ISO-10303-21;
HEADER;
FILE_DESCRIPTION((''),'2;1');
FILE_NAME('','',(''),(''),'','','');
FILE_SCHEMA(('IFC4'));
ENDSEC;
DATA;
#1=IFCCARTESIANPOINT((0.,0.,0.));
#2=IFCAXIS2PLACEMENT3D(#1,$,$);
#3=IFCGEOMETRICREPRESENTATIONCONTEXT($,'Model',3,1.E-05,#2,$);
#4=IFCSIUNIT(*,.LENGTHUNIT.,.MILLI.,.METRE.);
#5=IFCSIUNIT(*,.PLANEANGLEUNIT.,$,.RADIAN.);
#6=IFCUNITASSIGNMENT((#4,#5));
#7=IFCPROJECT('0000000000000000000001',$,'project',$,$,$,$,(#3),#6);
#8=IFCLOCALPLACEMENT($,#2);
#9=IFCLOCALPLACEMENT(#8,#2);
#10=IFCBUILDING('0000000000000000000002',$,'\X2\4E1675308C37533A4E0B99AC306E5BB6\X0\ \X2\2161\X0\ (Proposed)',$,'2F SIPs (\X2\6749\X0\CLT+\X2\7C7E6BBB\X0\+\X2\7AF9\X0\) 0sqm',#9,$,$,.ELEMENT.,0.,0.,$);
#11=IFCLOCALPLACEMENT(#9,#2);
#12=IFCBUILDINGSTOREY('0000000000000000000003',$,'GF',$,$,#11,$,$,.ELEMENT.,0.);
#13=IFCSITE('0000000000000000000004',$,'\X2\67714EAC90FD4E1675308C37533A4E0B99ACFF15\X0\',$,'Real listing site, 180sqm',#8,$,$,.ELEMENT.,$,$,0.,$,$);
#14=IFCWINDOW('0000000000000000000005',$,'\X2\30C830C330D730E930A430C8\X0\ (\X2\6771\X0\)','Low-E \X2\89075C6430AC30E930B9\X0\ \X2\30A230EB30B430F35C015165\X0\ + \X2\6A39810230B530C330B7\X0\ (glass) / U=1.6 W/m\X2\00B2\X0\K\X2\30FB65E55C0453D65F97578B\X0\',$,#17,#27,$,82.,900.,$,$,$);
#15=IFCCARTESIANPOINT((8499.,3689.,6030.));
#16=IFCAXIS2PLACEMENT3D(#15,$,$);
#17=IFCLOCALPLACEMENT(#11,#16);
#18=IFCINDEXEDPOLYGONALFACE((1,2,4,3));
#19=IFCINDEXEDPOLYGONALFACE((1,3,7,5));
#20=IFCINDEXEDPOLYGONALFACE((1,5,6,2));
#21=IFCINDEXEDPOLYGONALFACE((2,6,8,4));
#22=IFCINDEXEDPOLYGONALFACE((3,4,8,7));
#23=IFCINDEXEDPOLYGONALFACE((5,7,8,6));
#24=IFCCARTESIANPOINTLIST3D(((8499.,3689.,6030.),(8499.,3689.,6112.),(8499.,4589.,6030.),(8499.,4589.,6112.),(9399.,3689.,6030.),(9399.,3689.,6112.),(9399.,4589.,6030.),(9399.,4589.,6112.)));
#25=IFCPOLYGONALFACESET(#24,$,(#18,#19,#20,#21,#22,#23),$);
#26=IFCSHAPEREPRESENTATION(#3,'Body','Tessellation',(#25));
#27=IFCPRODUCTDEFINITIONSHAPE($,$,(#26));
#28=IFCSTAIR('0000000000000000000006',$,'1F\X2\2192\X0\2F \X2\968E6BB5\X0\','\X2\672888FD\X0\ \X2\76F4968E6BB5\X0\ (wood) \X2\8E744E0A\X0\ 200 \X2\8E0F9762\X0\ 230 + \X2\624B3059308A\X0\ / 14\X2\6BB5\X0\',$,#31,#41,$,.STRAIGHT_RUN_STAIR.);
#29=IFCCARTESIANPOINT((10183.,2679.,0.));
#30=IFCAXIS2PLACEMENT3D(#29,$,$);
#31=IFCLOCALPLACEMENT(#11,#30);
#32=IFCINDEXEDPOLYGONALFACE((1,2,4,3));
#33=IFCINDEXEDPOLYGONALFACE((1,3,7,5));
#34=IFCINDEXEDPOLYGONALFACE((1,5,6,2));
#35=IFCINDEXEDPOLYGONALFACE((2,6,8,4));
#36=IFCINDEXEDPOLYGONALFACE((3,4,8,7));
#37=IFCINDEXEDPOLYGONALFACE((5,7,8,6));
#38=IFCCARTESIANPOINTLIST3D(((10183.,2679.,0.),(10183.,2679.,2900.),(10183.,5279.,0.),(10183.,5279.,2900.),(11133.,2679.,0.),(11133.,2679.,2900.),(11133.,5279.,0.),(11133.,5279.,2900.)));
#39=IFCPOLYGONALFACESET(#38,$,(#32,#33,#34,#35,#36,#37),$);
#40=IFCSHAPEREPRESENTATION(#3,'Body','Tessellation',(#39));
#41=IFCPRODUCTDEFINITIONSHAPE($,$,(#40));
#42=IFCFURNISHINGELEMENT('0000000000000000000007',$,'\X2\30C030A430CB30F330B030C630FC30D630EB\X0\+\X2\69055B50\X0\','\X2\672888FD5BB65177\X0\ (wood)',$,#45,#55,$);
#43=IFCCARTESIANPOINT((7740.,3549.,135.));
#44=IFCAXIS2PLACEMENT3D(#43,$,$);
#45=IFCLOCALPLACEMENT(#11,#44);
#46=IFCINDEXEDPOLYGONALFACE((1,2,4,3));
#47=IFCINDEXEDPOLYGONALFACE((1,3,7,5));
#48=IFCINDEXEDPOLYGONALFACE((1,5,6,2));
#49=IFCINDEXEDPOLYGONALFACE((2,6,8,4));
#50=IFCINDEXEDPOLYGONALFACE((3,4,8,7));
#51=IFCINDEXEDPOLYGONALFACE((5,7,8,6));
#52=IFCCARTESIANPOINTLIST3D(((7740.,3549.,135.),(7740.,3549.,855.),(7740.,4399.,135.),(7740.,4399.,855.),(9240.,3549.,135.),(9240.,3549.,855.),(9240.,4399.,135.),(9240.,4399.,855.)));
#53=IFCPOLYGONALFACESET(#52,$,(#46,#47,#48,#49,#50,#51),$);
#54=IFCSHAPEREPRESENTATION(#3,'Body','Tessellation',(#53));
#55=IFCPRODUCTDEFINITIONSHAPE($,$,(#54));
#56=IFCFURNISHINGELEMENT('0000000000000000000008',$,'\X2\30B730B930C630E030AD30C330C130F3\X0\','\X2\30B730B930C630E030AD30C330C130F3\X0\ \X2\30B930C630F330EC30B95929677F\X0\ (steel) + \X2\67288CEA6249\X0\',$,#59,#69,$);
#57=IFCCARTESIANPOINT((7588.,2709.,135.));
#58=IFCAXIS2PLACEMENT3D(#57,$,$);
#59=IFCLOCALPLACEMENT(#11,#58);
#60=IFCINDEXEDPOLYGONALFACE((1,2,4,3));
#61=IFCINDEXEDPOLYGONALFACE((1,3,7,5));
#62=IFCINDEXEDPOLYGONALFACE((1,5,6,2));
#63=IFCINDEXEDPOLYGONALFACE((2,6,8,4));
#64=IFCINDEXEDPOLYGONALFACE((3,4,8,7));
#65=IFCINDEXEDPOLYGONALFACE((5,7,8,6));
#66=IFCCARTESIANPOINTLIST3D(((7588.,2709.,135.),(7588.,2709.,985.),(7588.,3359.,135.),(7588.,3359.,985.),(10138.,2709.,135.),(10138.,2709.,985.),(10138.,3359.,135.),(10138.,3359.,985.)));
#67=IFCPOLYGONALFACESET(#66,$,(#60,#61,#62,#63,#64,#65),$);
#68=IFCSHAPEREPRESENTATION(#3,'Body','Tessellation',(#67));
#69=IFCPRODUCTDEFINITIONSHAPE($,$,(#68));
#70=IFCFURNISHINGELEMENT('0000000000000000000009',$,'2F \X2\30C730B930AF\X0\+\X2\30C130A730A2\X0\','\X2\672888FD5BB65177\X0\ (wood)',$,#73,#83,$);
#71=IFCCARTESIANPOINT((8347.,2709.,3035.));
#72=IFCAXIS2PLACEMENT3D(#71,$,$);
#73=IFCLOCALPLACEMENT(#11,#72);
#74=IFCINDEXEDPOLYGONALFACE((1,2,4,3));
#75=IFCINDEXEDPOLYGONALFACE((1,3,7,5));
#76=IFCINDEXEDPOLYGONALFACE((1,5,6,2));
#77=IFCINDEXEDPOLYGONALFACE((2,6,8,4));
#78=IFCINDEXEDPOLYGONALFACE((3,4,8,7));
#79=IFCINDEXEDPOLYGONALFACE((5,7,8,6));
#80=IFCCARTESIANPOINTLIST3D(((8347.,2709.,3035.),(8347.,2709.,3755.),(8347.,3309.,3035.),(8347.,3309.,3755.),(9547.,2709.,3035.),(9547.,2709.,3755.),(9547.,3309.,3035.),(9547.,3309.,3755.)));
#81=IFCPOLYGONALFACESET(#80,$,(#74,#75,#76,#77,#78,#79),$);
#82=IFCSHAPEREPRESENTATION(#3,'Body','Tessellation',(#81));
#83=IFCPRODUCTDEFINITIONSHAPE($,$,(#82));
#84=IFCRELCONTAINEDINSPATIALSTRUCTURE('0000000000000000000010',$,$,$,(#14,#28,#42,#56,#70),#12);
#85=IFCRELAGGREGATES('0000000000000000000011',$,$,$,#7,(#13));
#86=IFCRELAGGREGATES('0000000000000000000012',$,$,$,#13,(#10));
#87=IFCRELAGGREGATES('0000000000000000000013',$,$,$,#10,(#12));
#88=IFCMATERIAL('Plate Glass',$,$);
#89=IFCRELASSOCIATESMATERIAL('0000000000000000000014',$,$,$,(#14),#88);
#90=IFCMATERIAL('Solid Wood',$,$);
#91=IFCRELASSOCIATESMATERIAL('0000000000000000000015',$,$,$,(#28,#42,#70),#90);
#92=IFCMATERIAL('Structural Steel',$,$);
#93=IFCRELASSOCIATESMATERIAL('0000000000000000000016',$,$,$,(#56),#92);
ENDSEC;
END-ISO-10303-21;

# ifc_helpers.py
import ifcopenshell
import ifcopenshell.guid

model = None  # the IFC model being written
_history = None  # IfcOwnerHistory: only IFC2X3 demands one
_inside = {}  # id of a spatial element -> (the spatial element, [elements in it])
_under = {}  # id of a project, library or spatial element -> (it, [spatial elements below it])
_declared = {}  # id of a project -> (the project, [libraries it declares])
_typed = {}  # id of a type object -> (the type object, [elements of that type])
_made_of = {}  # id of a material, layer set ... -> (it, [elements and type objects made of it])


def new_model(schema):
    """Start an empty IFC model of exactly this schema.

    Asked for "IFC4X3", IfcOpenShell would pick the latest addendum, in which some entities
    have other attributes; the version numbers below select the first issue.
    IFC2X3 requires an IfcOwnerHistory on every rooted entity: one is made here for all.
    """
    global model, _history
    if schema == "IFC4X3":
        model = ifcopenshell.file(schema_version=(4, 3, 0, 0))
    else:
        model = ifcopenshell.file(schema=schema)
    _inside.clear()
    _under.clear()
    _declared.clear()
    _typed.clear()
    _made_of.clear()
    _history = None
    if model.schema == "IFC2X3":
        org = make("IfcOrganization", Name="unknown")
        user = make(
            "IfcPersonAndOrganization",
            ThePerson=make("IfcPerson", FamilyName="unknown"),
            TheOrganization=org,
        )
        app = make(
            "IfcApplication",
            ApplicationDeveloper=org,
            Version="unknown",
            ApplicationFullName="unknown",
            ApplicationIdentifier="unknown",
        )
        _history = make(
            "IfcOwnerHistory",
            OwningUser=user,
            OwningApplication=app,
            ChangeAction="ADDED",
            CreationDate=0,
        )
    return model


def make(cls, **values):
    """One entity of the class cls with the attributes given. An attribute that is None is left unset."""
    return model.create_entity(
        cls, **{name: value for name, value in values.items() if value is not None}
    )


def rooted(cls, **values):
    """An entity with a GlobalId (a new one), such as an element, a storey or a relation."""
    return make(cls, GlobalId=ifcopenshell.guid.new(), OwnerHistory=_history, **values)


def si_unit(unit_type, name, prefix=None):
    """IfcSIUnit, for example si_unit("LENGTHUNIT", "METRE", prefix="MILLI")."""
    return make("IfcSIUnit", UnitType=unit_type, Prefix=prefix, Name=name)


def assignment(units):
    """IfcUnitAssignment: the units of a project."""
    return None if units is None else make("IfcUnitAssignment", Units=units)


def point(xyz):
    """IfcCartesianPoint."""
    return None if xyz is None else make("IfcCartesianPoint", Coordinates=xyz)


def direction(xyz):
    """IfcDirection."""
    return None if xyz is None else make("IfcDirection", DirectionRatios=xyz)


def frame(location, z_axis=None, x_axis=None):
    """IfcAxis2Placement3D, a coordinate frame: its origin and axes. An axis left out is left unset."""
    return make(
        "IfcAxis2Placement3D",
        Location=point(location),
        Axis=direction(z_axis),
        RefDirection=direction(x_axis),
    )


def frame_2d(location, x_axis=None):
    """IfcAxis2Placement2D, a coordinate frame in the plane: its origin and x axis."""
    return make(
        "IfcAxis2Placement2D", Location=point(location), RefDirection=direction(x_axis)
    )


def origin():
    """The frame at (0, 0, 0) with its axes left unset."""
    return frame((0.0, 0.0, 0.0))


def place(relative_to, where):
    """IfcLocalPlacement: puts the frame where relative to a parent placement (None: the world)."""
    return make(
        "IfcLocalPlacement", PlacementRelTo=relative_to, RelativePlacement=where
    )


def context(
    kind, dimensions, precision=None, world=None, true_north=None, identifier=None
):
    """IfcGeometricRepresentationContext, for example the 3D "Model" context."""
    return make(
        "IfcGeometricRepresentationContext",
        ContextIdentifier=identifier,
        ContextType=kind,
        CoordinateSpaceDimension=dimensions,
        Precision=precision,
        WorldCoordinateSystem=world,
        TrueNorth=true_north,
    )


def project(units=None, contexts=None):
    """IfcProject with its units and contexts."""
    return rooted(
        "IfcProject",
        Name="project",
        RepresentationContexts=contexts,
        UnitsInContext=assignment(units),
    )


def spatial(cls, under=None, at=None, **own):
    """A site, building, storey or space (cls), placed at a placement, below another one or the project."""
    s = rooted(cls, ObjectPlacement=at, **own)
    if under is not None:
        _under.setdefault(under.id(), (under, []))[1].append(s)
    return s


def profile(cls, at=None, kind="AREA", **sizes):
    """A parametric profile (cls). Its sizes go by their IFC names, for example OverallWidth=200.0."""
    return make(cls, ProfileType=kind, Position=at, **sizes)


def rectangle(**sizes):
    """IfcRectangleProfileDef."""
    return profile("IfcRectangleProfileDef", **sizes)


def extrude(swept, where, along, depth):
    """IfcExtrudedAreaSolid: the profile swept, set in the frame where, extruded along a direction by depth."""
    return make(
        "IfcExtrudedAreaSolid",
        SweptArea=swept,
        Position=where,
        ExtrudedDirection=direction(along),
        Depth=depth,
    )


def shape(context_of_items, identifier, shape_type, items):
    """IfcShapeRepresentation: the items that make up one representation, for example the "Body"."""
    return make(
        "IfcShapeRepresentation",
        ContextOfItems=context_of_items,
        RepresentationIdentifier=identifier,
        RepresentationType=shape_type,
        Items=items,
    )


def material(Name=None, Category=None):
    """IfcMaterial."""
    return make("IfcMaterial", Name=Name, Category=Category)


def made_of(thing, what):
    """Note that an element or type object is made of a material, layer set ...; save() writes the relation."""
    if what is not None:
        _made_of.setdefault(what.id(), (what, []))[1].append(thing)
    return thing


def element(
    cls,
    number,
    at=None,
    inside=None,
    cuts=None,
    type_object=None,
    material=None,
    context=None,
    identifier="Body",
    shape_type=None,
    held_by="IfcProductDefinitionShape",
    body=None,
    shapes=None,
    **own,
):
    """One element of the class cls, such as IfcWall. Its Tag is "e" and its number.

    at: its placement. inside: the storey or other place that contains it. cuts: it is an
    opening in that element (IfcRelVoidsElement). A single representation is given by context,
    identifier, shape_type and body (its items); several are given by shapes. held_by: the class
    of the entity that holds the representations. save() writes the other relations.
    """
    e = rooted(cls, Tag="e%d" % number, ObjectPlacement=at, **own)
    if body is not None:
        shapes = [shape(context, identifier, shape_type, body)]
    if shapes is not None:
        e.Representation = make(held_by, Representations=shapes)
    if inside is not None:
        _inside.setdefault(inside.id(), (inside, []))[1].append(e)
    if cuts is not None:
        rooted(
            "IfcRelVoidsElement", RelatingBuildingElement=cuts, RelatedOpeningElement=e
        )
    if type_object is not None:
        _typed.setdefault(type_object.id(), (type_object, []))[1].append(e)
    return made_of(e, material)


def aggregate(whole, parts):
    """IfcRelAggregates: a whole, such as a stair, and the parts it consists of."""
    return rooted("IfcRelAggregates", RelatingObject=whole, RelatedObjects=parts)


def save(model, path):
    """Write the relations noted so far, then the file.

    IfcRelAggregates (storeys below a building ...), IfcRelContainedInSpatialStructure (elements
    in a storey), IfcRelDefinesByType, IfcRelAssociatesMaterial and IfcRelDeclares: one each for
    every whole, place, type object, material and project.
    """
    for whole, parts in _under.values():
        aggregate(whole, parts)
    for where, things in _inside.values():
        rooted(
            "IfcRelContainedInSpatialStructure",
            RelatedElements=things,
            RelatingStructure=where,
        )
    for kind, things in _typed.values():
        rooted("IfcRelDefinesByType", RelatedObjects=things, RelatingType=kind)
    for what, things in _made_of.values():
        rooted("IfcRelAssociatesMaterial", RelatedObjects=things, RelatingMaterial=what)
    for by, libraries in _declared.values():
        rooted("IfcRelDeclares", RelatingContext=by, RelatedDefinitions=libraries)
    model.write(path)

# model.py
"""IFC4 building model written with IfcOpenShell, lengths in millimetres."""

from ifc_helpers import new_model, si_unit, frame, frame_2d, origin, place, context, project, spatial, rectangle, extrude, material, element, save


model = new_model("IFC4")

# Units and contexts
model_context = context("Model", 3, precision=1e-05, world=origin())
ifc_project = project(units=[si_unit("LENGTHUNIT", "METRE", prefix="MILLI"), si_unit("PLANEANGLEUNIT", "RADIAN")], contexts=[model_context])

# Site, building, storey
site_placement = place(None, origin())
site = spatial("IfcSite", under=ifc_project, at=site_placement, Name="東京都世田谷区下馬５", ObjectType="Real listing site, 180sqm", CompositionType="ELEMENT", RefElevation=0.0)
building_placement = place(site_placement, origin())
building = spatial("IfcBuilding", under=site, at=building_placement, Name="世田谷区下馬の家 Ⅱ (Proposed)", ObjectType="2F SIPs (杉CLT+籾殻+竹) 0sqm", CompositionType="ELEMENT", ElevationOfRefHeight=0.0, ElevationOfTerrain=0.0)
storey_placement = place(building_placement, origin())
storey = spatial("IfcBuildingStorey", under=building, at=storey_placement, Name="GF", CompositionType="ELEMENT", Elevation=0.0)

# Shared definitions
ifc_material_1 = material(Name="Solid Wood")

# Shared definitions
ifc_material_2 = material(Name="Plate Glass")

# Window
window_1_placement = place(storey_placement, frame((8499.0, 3689.0, 6030.0)))
element("IfcWindow", 1, at=window_1_placement, inside=storey, material=ifc_material_2, Name="トップライト (東)", Description="Low-E 複層ガラス アルゴン封入 + 樹脂サッシ (glass) / U=1.6 W/m²K・日射取得型", OverallHeight=82.0, OverallWidth=900.0, context=model_context, shape_type="SweptSolid", body=[
    extrude(rectangle(XDim=900.0, YDim=900.0, at=frame_2d((450.0, 450.0))), frame((8499.0, 3689.0, 6030.0)), (0.0, 0.0, 1.0), 82.0),
])

# Stair
stair_placement = place(storey_placement, frame((10183.0, 2679.0, 0.0)))
element("IfcStair", 2, at=stair_placement, inside=storey, material=ifc_material_1, Name="1F→2F 階段", Description="木製 直階段 (wood) 蹴上 200 踏面 230 + 手すり / 14段", PredefinedType="STRAIGHT_RUN_STAIR", context=model_context, shape_type="SweptSolid", body=[
    extrude(rectangle(XDim=950.0, YDim=2600.0, at=frame_2d((475.0, 1300.0))), frame((10183.0, 2679.0, 0.0)), (0.0, 0.0, 1.0), 2900.0),
])

# Furnishing elements
furnishing_1_placement = place(storey_placement, frame((7740.0, 3549.0, 135.0)))
element("IfcFurnishingElement", 3, at=furnishing_1_placement, inside=storey, material=ifc_material_1, Name="ダイニングテーブル+椅子", Description="木製家具 (wood)", context=model_context, shape_type="SweptSolid", body=[
    extrude(rectangle(XDim=1500.0, YDim=850.0, at=frame_2d((750.0, 425.0))), frame((7740.0, 3549.0, 135.0)), (0.0, 0.0, 1.0), 720.0),
])
ifc_material_3 = material(Name="Structural Steel")
furnishing_2_placement = place(storey_placement, frame((7588.0, 2709.0, 135.0)))
element("IfcFurnishingElement", 4, at=furnishing_2_placement, inside=storey, material=ifc_material_3, Name="システムキッチン", Description="システムキッチン ステンレス天板 (steel) + 木質扉", context=model_context, shape_type="SweptSolid", body=[
    extrude(rectangle(XDim=2550.0, YDim=650.0, at=frame_2d((1275.0, 325.0))), frame((7588.0, 2709.0, 135.0)), (0.0, 0.0, 1.0), 850.0),
])
furnishing_3_placement = place(storey_placement, frame((8347.0, 2709.0, 3035.0)))
element("IfcFurnishingElement", 5, at=furnishing_3_placement, inside=storey, material=ifc_material_1, Name="2F デスク+チェア", Description="木製家具 (wood)", context=model_context, shape_type="SweptSolid", body=[
    extrude(rectangle(XDim=1200.0, YDim=600.0, at=frame_2d((600.0, 300.0))), frame((8347.0, 2709.0, 3035.0)), (0.0, 0.0, 1.0), 720.0),
])

save(model, "model.ifc")
